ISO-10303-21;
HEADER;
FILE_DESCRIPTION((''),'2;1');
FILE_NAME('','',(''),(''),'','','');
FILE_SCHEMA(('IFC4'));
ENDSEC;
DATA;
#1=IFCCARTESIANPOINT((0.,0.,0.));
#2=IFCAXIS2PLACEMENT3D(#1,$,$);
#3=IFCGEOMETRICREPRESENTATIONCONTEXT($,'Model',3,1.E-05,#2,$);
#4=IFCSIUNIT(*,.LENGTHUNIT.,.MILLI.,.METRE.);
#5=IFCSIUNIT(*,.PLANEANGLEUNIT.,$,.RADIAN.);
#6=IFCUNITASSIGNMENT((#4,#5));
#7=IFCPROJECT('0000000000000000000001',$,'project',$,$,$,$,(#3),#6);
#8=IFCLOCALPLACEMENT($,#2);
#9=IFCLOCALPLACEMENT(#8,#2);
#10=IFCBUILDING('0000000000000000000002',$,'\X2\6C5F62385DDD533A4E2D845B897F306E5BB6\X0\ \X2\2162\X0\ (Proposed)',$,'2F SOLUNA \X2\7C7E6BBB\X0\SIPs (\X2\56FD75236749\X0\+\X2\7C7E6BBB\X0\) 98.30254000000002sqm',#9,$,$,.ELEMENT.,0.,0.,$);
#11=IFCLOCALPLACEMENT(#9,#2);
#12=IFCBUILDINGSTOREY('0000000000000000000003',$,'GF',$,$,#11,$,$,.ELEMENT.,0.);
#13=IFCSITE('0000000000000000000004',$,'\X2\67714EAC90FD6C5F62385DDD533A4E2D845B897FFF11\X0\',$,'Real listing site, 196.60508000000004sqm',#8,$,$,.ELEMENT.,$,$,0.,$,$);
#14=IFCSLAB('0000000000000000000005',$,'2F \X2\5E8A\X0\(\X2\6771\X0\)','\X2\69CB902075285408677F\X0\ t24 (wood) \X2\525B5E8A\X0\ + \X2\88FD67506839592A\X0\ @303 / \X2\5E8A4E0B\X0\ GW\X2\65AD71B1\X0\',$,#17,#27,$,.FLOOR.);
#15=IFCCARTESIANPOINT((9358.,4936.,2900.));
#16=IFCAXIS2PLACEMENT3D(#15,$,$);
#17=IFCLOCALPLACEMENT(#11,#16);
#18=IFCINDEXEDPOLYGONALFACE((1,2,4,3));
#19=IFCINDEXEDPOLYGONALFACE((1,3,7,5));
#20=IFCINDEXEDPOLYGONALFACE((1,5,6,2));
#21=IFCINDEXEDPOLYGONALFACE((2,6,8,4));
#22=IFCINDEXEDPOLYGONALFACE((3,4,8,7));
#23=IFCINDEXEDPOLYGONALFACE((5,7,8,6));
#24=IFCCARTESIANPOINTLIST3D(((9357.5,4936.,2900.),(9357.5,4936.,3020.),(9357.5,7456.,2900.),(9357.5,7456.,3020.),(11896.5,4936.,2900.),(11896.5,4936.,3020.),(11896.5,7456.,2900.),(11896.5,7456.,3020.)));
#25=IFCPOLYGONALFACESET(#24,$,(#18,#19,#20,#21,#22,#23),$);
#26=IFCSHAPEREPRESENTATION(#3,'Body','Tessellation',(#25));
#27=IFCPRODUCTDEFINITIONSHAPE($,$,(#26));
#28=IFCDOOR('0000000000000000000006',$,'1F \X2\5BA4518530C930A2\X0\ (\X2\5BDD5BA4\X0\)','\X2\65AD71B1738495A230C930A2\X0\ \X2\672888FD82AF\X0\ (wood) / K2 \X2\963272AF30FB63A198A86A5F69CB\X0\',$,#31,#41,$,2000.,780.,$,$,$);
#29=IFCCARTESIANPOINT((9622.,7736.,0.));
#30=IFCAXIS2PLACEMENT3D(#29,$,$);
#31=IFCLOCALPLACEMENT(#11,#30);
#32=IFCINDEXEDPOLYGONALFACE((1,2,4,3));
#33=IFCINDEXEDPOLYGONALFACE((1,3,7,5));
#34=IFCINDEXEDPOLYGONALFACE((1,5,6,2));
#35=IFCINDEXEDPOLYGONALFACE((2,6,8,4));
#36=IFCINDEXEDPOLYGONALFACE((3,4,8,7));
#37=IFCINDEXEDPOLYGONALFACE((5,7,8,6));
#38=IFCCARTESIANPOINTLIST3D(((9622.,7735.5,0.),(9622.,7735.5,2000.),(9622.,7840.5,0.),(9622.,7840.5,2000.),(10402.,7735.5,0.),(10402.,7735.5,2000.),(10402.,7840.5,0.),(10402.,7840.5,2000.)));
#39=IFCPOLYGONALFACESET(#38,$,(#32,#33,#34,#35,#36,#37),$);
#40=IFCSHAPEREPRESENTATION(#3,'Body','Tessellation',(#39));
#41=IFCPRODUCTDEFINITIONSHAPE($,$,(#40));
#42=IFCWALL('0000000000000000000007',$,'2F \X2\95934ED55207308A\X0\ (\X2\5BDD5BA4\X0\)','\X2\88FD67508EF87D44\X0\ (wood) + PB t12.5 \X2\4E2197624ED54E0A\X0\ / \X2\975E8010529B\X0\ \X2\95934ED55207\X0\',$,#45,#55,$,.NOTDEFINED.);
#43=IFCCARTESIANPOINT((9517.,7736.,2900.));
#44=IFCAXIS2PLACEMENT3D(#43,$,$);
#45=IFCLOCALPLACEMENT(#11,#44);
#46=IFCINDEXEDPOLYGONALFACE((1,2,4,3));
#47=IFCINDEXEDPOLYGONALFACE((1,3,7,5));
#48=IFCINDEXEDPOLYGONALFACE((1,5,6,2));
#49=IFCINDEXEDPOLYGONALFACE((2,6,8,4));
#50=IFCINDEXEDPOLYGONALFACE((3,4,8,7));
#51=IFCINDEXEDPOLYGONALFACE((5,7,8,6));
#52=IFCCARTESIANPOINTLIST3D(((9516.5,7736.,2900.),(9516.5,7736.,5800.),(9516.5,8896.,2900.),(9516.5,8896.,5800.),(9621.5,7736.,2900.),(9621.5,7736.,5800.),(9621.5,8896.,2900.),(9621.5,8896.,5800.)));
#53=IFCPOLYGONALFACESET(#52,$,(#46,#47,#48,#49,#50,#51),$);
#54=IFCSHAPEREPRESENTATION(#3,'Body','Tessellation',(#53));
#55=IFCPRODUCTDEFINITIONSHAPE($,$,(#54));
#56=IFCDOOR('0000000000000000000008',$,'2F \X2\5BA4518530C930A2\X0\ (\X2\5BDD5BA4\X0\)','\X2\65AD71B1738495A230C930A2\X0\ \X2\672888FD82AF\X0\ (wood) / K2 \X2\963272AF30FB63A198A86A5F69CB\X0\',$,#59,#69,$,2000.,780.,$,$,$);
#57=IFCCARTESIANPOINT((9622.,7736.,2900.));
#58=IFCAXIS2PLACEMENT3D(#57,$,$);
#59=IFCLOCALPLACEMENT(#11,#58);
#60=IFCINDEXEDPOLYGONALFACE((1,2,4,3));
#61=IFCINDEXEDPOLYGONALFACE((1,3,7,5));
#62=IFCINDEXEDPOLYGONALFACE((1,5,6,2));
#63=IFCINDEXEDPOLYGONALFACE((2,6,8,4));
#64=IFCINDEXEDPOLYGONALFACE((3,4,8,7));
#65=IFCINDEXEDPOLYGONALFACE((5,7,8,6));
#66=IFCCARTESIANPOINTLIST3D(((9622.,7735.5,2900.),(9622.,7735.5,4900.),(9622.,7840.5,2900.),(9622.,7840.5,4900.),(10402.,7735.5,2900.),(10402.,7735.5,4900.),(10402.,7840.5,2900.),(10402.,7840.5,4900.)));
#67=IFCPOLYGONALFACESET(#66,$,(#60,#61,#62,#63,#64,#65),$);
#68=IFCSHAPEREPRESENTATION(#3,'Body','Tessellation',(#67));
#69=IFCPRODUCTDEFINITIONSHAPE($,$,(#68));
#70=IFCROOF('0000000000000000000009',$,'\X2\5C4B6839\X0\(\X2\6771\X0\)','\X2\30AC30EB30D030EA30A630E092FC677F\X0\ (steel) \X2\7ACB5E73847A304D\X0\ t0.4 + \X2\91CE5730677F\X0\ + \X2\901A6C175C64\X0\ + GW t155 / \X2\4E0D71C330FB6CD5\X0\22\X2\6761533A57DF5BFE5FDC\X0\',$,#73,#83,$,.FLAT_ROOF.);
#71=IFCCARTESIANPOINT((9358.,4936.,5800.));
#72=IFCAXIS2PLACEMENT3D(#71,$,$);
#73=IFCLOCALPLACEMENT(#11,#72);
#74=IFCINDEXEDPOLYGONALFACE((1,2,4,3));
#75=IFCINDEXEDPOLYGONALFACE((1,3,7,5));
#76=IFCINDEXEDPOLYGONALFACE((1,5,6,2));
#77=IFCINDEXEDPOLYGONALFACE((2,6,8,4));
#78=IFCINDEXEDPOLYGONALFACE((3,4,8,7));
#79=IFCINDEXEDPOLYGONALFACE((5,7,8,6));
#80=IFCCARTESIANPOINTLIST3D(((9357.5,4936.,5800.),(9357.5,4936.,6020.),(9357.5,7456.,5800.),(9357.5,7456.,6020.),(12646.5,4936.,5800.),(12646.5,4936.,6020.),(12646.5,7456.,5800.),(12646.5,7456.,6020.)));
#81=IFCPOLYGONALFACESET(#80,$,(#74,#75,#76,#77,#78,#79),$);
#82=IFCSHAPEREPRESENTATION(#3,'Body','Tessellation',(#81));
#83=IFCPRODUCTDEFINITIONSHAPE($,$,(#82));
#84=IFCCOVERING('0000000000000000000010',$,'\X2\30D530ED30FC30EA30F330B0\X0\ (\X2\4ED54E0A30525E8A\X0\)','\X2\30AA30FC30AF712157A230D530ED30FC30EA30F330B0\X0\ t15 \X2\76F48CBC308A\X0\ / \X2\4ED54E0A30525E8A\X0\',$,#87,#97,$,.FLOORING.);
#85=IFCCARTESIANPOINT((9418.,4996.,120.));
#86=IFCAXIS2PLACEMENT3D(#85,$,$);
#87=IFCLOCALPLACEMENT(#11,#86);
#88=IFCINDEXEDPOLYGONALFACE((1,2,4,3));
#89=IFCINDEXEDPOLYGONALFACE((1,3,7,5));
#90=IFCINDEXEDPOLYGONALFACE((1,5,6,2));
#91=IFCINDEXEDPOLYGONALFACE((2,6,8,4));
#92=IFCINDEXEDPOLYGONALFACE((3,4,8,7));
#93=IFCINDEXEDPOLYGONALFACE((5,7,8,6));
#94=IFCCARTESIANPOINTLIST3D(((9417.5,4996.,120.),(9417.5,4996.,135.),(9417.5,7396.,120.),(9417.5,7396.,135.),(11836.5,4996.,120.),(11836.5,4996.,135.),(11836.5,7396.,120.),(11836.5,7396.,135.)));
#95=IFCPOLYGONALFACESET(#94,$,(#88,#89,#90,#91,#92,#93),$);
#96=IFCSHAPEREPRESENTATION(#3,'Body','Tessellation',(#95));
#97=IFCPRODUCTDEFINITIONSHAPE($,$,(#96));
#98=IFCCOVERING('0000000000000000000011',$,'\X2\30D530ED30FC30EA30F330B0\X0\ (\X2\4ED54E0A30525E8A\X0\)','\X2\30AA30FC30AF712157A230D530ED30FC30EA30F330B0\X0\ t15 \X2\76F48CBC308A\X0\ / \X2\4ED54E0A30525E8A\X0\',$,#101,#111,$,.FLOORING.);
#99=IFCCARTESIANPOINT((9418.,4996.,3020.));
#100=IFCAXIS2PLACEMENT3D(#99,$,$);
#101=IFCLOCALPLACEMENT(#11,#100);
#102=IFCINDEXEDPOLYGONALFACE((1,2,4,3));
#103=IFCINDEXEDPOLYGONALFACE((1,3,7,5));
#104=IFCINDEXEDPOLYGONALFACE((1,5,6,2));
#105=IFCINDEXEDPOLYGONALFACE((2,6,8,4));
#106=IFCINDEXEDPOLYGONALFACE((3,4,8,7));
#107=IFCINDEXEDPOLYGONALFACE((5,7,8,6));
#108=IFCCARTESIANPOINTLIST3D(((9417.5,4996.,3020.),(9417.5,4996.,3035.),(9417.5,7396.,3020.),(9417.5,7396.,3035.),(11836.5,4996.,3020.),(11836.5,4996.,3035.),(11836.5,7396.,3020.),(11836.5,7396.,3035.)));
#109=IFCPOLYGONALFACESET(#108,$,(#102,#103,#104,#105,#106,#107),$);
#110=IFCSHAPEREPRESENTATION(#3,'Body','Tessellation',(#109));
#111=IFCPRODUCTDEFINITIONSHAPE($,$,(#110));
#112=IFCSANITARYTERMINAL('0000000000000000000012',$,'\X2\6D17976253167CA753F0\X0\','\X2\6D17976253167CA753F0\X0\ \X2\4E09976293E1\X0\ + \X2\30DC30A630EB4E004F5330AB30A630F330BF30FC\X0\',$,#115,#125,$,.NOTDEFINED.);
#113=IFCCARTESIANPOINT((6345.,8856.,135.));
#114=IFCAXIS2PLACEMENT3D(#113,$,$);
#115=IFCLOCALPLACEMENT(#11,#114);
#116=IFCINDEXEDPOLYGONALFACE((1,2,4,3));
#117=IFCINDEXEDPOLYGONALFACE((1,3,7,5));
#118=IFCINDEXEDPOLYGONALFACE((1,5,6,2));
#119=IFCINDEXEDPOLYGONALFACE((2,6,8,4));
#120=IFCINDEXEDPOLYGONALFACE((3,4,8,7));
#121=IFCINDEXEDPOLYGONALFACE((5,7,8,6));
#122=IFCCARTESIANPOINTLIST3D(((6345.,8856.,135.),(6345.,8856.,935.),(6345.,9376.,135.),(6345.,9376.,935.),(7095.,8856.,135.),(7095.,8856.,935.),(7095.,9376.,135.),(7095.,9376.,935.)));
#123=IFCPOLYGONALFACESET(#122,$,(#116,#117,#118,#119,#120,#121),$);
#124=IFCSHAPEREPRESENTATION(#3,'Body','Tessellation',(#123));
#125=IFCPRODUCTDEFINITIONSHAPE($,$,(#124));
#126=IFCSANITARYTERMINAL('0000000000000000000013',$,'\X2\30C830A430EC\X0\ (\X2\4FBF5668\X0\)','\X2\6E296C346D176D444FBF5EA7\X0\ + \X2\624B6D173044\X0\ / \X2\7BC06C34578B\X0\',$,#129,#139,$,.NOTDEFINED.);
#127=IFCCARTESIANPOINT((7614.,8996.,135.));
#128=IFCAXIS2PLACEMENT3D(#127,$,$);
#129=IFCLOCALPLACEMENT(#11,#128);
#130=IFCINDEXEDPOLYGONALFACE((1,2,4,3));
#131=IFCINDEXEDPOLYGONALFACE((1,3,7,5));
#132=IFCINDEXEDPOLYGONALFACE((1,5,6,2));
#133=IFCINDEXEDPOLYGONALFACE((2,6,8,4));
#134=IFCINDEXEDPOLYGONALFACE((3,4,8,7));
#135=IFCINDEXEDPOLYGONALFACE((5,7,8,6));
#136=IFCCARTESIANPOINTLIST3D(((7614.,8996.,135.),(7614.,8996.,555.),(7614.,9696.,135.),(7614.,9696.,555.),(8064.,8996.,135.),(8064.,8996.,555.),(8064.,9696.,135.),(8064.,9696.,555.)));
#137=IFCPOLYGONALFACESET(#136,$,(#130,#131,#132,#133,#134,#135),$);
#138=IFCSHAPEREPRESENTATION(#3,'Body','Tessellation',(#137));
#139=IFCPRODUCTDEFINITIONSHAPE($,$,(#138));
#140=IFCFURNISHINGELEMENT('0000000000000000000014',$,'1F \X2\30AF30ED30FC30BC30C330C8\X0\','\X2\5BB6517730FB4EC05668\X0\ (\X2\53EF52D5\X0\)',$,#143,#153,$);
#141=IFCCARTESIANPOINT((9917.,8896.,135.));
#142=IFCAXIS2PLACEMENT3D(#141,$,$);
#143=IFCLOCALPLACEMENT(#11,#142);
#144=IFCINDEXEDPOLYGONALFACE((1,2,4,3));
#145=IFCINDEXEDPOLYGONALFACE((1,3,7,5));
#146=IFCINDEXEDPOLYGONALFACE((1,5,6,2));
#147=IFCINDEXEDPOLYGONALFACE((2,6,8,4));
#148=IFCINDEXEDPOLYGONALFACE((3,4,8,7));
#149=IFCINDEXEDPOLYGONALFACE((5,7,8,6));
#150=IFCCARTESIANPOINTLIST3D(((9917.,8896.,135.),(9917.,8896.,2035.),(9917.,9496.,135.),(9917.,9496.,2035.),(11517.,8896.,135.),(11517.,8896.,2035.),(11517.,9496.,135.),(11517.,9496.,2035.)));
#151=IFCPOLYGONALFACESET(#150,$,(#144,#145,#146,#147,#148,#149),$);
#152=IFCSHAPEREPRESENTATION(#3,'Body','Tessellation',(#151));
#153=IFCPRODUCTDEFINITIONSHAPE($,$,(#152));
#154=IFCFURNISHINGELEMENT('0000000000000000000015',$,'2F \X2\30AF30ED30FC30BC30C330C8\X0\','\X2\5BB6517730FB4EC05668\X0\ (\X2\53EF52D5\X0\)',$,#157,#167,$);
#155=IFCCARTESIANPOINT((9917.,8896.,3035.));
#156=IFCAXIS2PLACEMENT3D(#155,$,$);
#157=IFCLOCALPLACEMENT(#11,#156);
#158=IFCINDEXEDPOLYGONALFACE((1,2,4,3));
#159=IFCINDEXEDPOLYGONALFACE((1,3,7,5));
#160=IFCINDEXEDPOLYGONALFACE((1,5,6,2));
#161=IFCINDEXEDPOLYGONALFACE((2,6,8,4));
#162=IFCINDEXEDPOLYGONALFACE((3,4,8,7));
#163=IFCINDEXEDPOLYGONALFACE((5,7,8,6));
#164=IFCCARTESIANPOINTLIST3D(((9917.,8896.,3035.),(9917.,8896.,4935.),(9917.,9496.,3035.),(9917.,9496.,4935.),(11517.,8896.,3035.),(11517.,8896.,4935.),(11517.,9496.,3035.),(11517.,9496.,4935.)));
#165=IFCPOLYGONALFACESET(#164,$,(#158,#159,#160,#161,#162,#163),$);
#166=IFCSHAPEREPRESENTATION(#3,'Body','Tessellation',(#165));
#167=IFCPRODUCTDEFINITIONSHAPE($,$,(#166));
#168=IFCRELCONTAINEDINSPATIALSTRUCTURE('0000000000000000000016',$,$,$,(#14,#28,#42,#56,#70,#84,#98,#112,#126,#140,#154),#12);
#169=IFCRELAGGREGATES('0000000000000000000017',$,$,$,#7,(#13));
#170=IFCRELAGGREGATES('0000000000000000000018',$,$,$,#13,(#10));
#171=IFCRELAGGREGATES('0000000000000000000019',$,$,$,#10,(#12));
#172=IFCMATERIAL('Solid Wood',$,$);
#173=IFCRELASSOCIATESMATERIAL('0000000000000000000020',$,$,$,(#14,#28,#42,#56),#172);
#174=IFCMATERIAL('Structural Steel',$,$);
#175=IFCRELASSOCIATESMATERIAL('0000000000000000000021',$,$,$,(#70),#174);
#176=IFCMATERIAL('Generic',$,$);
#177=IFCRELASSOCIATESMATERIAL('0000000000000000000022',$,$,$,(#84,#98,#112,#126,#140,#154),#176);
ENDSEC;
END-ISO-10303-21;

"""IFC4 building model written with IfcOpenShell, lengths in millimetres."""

from ifc_helpers import new_model, si_unit, frame, frame_2d, origin, place, context, project, spatial, rectangle, extrude, material, element, save


model = new_model("IFC4")

# Units and contexts
model_context = context("Model", 3, precision=1e-05, world=origin())
ifc_project = project(units=[si_unit("LENGTHUNIT", "METRE", prefix="MILLI"), si_unit("PLANEANGLEUNIT", "RADIAN")], contexts=[model_context])

# Site, building, storey
site_placement = place(None, origin())
site = spatial("IfcSite", under=ifc_project, at=site_placement, Name="東京都江戸川区中葛西１", ObjectType="Real listing site, 196.60508000000004sqm", CompositionType="ELEMENT", RefElevation=0.0)
building_placement = place(site_placement, origin())
building = spatial("IfcBuilding", under=site, at=building_placement, Name="江戸川区中葛西の家 Ⅲ (Proposed)", ObjectType="2F SOLUNA 籾殻SIPs (国産杉+籾殻) 98.30254000000002sqm", CompositionType="ELEMENT", ElevationOfRefHeight=0.0, ElevationOfTerrain=0.0)
storey_placement = place(building_placement, origin())
storey = spatial("IfcBuildingStorey", under=building, at=storey_placement, Name="GF", CompositionType="ELEMENT", Elevation=0.0)

# Slab
ifc_material_1 = material(Name="Solid Wood")
slab_1_placement = place(storey_placement, frame((9358.0, 4936.0, 2900.0)))
element("IfcSlab", 1, at=slab_1_placement, inside=storey, material=ifc_material_1, Name="2F 床(東)", Description="構造用合板 t24 (wood) 剛床 + 製材根太 @303 / 床下 GW断熱", PredefinedType="FLOOR", context=model_context, shape_type="SweptSolid", body=[
    extrude(rectangle(XDim=2539.0, YDim=2520.0, at=frame_2d((1269.0, 1260.0))), frame((9358.0, 4936.0, 2900.0)), (0.0, 0.0, 1.0), 120.0),
])

# Door
door_1_placement = place(storey_placement, frame((9622.0, 7736.0, 0.0)))
element("IfcDoor", 2, at=door_1_placement, inside=storey, material=ifc_material_1, Name="1F 室内ドア (寝室)", Description="断熱玄関ドア 木製芯 (wood) / K2 防犯・採風機構", OverallHeight=2000.0, OverallWidth=780.0, context=model_context, shape_type="SweptSolid", body=[
    extrude(rectangle(XDim=780.0, YDim=105.0, at=frame_2d((390.0, 52.0))), frame((9622.0, 7736.0, 0.0)), (0.0, 0.0, 1.0), 2000.0),
])

# Wall
wall_1_placement = place(storey_placement, frame((9517.0, 7736.0, 2900.0)))
element("IfcWall", 3, at=wall_1_placement, inside=storey, material=ifc_material_1, Name="2F 間仕切り (寝室)", Description="製材軸組 (wood) + PB t12.5 両面仕上 / 非耐力 間仕切", PredefinedType="NOTDEFINED", context=model_context, shape_type="SweptSolid", body=[
    extrude(rectangle(XDim=105.0, YDim=1160.0, at=frame_2d((52.0, 580.0))), frame((9517.0, 7736.0, 2900.0)), (0.0, 0.0, 1.0), 2900.0),
])

# Door
door_2_placement = place(storey_placement, frame((9622.0, 7736.0, 2900.0)))
element("IfcDoor", 4, at=door_2_placement, inside=storey, material=ifc_material_1, Name="2F 室内ドア (寝室)", Description="断熱玄関ドア 木製芯 (wood) / K2 防犯・採風機構", OverallHeight=2000.0, OverallWidth=780.0, context=model_context, shape_type="SweptSolid", body=[
    extrude(rectangle(XDim=780.0, YDim=105.0, at=frame_2d((390.0, 52.0))), frame((9622.0, 7736.0, 2900.0)), (0.0, 0.0, 1.0), 2000.0),
])

# Roof
ifc_material_2 = material(Name="Structural Steel")
for number, where, name in (
    (5, (9358.0, 4936.0, 5800.0), "屋根(東)"),
):
    element("IfcRoof", number, at=place(storey_placement, frame(where)), inside=storey, material=ifc_material_2, Name=name, Description="ガルバリウム鋼板 (steel) 立平葺き t0.4 + 野地板 + 通気層 + GW t155 / 不燃・法22条区域対応", PredefinedType="FLAT_ROOF", context=model_context, shape_type="SweptSolid", body=[
        extrude(rectangle(XDim=3289.0, YDim=2520.0, at=frame_2d((1644.0, 1260.0))), frame((9358.0, 4936.0, 5800.0)), (0.0, 0.0, 1.0), 220.0),
    ])

# Coverings
ifc_material_3 = material(Name="Generic")
covering_1_placement = place(storey_placement, frame((9418.0, 4996.0, 120.0)))
element("IfcCovering", 6, at=covering_1_placement, inside=storey, material=ifc_material_3, Name="フローリング (仕上げ床)", Description="オーク無垢フローリング t15 直貼り / 仕上げ床", PredefinedType="FLOORING", context=model_context, shape_type="SweptSolid", body=[
    extrude(rectangle(XDim=2419.0, YDim=2400.0, at=frame_2d((1209.0, 1200.0))), frame((9418.0, 4996.0, 120.0)), (0.0, 0.0, 1.0), 15.0),
])
covering_2_placement = place(storey_placement, frame((9418.0, 4996.0, 3020.0)))
element("IfcCovering", 7, at=covering_2_placement, inside=storey, material=ifc_material_3, Name="フローリング (仕上げ床)", Description="オーク無垢フローリング t15 直貼り / 仕上げ床", PredefinedType="FLOORING", context=model_context, shape_type="SweptSolid", body=[
    extrude(rectangle(XDim=2419.0, YDim=2400.0, at=frame_2d((1209.0, 1200.0))), frame((9418.0, 4996.0, 3020.0)), (0.0, 0.0, 1.0), 15.0),
])

# Sanitary terminals
sanitary_terminal_1_placement = place(storey_placement, frame((6345.0, 8856.0, 135.0)))
element("IfcSanitaryTerminal", 8, at=sanitary_terminal_1_placement, inside=storey, material=ifc_material_3, Name="洗面化粧台", Description="洗面化粧台 三面鏡 + ボウル一体カウンター", PredefinedType="NOTDEFINED", context=model_context, shape_type="SweptSolid", body=[
    extrude(rectangle(XDim=750.0, YDim=520.0, at=frame_2d((375.0, 260.0))), frame((6345.0, 8856.0, 135.0)), (0.0, 0.0, 1.0), 800.0),
])
sanitary_terminal_2_placement = place(storey_placement, frame((7614.0, 8996.0, 135.0)))
element("IfcSanitaryTerminal", 9, at=sanitary_terminal_2_placement, inside=storey, material=ifc_material_3, Name="トイレ (便器)", Description="温水洗浄便座 + 手洗い / 節水型", PredefinedType="NOTDEFINED", context=model_context, shape_type="SweptSolid", body=[
    extrude(rectangle(XDim=450.0, YDim=700.0, at=frame_2d((225.0, 350.0))), frame((7614.0, 8996.0, 135.0)), (0.0, 0.0, 1.0), 420.0),
])

# Furnishing elements
furnishing_1_placement = place(storey_placement, frame((9917.0, 8896.0, 135.0)))
element("IfcFurnishingElement", 10, at=furnishing_1_placement, inside=storey, material=ifc_material_3, Name="1F クローゼット", Description="家具・什器 (可動)", context=model_context, shape_type="SweptSolid", body=[
    extrude(rectangle(XDim=1600.0, YDim=600.0, at=frame_2d((800.0, 300.0))), frame((9917.0, 8896.0, 135.0)), (0.0, 0.0, 1.0), 1900.0),
])
furnishing_2_placement = place(storey_placement, frame((9917.0, 8896.0, 3035.0)))
element("IfcFurnishingElement", 11, at=furnishing_2_placement, inside=storey, material=ifc_material_3, Name="2F クローゼット", Description="家具・什器 (可動)", context=model_context, shape_type="SweptSolid", body=[
    extrude(rectangle(XDim=1600.0, YDim=600.0, at=frame_2d((800.0, 300.0))), frame((9917.0, 8896.0, 3035.0)), (0.0, 0.0, 1.0), 1900.0),
])

save(model, "model.ifc")
